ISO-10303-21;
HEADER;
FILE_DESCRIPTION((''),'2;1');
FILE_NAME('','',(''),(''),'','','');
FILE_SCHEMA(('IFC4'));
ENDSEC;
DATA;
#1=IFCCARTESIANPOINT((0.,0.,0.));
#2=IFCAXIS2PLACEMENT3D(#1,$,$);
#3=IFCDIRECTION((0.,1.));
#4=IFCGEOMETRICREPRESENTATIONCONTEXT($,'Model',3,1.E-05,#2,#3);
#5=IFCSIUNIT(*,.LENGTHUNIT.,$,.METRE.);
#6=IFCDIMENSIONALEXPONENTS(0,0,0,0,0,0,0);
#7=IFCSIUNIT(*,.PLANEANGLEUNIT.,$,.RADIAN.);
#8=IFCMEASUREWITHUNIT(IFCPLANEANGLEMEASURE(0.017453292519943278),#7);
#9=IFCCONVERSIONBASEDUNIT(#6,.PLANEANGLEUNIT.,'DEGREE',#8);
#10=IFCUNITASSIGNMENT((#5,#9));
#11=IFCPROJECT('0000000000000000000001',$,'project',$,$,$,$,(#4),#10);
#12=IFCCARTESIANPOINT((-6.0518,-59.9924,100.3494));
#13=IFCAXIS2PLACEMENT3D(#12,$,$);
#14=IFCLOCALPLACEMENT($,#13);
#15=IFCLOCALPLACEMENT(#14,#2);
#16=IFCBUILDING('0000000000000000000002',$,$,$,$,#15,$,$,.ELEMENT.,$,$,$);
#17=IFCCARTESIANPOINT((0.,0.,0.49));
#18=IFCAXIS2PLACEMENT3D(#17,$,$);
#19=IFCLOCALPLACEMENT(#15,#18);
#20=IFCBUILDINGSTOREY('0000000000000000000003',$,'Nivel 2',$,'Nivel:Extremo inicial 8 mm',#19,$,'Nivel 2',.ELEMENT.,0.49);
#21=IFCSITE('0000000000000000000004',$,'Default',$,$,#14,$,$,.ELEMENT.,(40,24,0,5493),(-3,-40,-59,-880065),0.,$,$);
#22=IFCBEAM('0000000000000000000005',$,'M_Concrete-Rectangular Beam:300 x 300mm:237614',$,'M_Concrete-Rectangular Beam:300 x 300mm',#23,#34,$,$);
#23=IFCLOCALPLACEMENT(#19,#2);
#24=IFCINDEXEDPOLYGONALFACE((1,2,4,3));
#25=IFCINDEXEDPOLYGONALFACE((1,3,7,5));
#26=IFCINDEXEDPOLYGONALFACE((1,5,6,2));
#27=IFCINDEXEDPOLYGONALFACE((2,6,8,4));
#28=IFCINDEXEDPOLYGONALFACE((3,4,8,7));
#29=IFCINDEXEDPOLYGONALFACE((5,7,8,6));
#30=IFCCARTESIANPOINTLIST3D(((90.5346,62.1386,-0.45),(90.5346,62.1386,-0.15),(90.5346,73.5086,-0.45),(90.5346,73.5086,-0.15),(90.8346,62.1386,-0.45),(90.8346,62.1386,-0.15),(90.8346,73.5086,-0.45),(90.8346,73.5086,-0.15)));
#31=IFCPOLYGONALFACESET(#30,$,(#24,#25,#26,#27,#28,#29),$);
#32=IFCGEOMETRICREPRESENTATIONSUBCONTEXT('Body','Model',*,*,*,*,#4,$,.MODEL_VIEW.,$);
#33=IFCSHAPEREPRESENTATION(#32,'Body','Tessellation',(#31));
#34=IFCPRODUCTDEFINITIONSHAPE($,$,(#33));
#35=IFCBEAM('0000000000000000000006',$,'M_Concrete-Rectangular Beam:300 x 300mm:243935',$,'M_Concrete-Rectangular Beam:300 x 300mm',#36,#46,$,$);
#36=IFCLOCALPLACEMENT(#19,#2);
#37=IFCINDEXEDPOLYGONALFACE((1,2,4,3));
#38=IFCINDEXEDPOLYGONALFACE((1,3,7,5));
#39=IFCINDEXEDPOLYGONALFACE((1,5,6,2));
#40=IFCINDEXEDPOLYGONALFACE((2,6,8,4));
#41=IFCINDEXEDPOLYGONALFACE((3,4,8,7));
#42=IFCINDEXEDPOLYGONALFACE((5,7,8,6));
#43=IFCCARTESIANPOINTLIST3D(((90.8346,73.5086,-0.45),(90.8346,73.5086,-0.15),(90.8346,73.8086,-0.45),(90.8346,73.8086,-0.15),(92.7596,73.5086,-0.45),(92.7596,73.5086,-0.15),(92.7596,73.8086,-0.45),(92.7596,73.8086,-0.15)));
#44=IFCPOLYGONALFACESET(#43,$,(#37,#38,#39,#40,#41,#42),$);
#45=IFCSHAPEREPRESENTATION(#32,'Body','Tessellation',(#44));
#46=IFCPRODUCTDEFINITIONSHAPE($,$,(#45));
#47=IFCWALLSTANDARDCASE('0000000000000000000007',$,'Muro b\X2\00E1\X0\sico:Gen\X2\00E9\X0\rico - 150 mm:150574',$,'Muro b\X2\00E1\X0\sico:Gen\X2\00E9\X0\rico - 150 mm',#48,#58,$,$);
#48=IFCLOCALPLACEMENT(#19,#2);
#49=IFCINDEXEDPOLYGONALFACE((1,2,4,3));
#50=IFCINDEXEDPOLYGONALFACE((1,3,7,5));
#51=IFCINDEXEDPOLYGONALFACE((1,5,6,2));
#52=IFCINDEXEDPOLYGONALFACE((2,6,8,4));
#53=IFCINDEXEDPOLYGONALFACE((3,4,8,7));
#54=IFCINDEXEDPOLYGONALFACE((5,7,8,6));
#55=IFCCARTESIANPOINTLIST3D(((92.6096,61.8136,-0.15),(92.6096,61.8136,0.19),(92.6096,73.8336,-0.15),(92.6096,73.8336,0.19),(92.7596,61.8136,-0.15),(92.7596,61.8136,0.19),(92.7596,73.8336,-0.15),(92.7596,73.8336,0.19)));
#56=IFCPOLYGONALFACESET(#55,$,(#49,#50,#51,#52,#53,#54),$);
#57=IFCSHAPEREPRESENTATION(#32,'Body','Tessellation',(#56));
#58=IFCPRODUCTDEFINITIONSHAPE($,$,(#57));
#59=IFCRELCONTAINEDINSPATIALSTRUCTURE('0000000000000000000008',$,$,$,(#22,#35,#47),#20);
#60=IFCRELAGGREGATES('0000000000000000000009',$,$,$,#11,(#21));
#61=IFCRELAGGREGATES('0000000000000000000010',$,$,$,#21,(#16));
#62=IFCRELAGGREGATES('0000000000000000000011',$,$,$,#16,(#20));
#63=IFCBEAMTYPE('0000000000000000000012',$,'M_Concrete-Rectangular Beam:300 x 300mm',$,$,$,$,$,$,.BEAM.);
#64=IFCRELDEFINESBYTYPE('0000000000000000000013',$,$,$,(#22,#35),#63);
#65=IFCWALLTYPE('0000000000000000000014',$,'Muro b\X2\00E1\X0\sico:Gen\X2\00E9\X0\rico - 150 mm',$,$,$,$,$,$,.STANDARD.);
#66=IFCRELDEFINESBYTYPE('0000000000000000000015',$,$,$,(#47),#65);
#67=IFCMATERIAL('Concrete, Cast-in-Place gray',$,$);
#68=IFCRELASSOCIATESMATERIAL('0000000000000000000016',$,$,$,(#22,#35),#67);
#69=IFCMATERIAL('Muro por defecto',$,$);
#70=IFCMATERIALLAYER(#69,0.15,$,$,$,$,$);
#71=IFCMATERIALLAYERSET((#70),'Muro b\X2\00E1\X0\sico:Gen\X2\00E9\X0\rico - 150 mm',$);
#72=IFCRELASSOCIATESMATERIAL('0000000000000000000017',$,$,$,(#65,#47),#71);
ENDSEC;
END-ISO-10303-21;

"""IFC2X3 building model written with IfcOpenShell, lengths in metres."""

from ifc_helpers import new_model, entity, si_unit, converted_unit, direction, frame, frame_2d, origin, origin_2d_with_axis, place, context, subcontext, project, spatial, polyline, rectangle, extrude, clip, bounded_halfspace, material, layer, layer_set, layer_usage, type_object, element, save


model = new_model("IFC2X3")

# Units and contexts
model_context = context("Model", 3, precision=1e-05, world=origin(), true_north=direction((0.0, 1.0)))
body_context = subcontext(model_context, "Body", "Model", "MODEL_VIEW")
ifc_project = project(units=[si_unit("LENGTHUNIT", "METRE"), converted_unit("PLANEANGLEUNIT", "DEGREE", entity("IfcPlaneAngleMeasure", 0.017453292519943278), si_unit("PLANEANGLEUNIT", "RADIAN"), dimensions=[0, 0, 0, 0, 0, 0, 0])], contexts=[model_context])

# Site, building, storey
site_placement = place(None, frame((-6.0518, -59.9924, 100.3494)))
site = spatial("IfcSite", under=ifc_project, at=site_placement, Name="Default", CompositionType="ELEMENT", RefLatitude=(40, 24, 0, 5493), RefLongitude=(-3, -40, -59, -880065), RefElevation=0.0)
building_placement = place(site_placement, origin())
building = spatial("IfcBuilding", under=site, at=building_placement, CompositionType="ELEMENT")
storey_placement = place(building_placement, frame((0.0, 0.0, 0.49)))
storey = spatial("IfcBuildingStorey", under=building, at=storey_placement, Name="Nivel 2", ObjectType="Nivel:Extremo inicial 8 mm", LongName="Nivel 2", CompositionType="ELEMENT", Elevation=0.49)

# Beams
ifc_material_1 = material(Name="Concrete, Cast-in-Place gray")
beam_type = type_object("IfcBeamType", Name="M_Concrete-Rectangular Beam:300 x 300mm", PredefinedType="BEAM")
beam_1_placement = place(storey_placement, frame((90.6846, 73.6586, 0.0), z_axis=(0.0, 0.0, 1.0), x_axis=(0.0, -1.0, 0.0)))
element("IfcBeam", 1, at=beam_1_placement, inside=storey, type_object=beam_type, material=ifc_material_1, Name="M_Concrete-Rectangular Beam:300 x 300mm:237614", ObjectType="M_Concrete-Rectangular Beam:300 x 300mm", context=body_context, shape_type="SweptSolid", body=[
    extrude(rectangle(XDim=0.3, YDim=0.3, at=origin_2d_with_axis()), frame((0.15, 0.0, -0.3), z_axis=(1.0, 0.0, 0.0), x_axis=(0.0, 0.0, -1.0)), (0.0, 0.0, 1.0), 11.37),
])
beam_2_placement = place(storey_placement, frame((90.6846, 73.6586, 0.0)))
element("IfcBeam", 2, at=beam_2_placement, inside=storey, type_object=beam_type, material=ifc_material_1, Name="M_Concrete-Rectangular Beam:300 x 300mm:243935", ObjectType="M_Concrete-Rectangular Beam:300 x 300mm", context=body_context, shape_type="SweptSolid", body=[
    extrude(rectangle(XDim=0.3, YDim=0.3, at=origin_2d_with_axis()), frame((0.15, 0.0, -0.3), z_axis=(1.0, 0.0, 0.0), x_axis=(0.0, 0.0, -1.0)), (0.0, 0.0, 1.0), 1.925),
])

# Wall
ifc_material_2 = material(Name="Muro por defecto")
ifc_layer = layer(ifc_material_2, 0.15)
ifc_layer_set = layer_set([ifc_layer], Name="Muro básico:Genérico - 150 mm")
ifc_layer_usage = layer_usage(ifc_layer_set, "AXIS2", "POSITIVE", -0.075)
wall_type = type_object("IfcWallType", Name="Muro básico:Genérico - 150 mm", PredefinedType="STANDARD", material=ifc_layer_set)
wall_placement = place(storey_placement, frame((92.6846, 73.8336, -0.15), z_axis=(0.0, 0.0, 1.0), x_axis=(0.0, -1.0, 0.0)))
element("IfcWallStandardCase", 3, at=wall_placement, inside=storey, type_object=wall_type, material=ifc_layer_usage, Name="Muro básico:Genérico - 150 mm:150574", ObjectType="Muro básico:Genérico - 150 mm", context=body_context, shape_type="Clipping", body=[
    clip(extrude(rectangle(XDim=12.02, YDim=0.15, at=frame_2d((6.01, 0.0), x_axis=(-1.0, 0.0))), origin(), (0.0, 0.0, 1.0), 0.34), bounded_halfspace(frame((0.0, -0.075, 0.34), z_axis=(0.0, 0.0, -1.0), x_axis=(1.0, 0.0, 0.0)), True, frame((0.0, -0.075, 0.34), z_axis=(0.0, 0.0, -1.0), x_axis=(1.0, 0.0, 0.0)), polyline([(0.0, 0.0), (0.0, -0.15), (12.02, -0.15), (12.02, 0.0), (0.0, 0.0)]))),
])

save(model, "model.ifc")
